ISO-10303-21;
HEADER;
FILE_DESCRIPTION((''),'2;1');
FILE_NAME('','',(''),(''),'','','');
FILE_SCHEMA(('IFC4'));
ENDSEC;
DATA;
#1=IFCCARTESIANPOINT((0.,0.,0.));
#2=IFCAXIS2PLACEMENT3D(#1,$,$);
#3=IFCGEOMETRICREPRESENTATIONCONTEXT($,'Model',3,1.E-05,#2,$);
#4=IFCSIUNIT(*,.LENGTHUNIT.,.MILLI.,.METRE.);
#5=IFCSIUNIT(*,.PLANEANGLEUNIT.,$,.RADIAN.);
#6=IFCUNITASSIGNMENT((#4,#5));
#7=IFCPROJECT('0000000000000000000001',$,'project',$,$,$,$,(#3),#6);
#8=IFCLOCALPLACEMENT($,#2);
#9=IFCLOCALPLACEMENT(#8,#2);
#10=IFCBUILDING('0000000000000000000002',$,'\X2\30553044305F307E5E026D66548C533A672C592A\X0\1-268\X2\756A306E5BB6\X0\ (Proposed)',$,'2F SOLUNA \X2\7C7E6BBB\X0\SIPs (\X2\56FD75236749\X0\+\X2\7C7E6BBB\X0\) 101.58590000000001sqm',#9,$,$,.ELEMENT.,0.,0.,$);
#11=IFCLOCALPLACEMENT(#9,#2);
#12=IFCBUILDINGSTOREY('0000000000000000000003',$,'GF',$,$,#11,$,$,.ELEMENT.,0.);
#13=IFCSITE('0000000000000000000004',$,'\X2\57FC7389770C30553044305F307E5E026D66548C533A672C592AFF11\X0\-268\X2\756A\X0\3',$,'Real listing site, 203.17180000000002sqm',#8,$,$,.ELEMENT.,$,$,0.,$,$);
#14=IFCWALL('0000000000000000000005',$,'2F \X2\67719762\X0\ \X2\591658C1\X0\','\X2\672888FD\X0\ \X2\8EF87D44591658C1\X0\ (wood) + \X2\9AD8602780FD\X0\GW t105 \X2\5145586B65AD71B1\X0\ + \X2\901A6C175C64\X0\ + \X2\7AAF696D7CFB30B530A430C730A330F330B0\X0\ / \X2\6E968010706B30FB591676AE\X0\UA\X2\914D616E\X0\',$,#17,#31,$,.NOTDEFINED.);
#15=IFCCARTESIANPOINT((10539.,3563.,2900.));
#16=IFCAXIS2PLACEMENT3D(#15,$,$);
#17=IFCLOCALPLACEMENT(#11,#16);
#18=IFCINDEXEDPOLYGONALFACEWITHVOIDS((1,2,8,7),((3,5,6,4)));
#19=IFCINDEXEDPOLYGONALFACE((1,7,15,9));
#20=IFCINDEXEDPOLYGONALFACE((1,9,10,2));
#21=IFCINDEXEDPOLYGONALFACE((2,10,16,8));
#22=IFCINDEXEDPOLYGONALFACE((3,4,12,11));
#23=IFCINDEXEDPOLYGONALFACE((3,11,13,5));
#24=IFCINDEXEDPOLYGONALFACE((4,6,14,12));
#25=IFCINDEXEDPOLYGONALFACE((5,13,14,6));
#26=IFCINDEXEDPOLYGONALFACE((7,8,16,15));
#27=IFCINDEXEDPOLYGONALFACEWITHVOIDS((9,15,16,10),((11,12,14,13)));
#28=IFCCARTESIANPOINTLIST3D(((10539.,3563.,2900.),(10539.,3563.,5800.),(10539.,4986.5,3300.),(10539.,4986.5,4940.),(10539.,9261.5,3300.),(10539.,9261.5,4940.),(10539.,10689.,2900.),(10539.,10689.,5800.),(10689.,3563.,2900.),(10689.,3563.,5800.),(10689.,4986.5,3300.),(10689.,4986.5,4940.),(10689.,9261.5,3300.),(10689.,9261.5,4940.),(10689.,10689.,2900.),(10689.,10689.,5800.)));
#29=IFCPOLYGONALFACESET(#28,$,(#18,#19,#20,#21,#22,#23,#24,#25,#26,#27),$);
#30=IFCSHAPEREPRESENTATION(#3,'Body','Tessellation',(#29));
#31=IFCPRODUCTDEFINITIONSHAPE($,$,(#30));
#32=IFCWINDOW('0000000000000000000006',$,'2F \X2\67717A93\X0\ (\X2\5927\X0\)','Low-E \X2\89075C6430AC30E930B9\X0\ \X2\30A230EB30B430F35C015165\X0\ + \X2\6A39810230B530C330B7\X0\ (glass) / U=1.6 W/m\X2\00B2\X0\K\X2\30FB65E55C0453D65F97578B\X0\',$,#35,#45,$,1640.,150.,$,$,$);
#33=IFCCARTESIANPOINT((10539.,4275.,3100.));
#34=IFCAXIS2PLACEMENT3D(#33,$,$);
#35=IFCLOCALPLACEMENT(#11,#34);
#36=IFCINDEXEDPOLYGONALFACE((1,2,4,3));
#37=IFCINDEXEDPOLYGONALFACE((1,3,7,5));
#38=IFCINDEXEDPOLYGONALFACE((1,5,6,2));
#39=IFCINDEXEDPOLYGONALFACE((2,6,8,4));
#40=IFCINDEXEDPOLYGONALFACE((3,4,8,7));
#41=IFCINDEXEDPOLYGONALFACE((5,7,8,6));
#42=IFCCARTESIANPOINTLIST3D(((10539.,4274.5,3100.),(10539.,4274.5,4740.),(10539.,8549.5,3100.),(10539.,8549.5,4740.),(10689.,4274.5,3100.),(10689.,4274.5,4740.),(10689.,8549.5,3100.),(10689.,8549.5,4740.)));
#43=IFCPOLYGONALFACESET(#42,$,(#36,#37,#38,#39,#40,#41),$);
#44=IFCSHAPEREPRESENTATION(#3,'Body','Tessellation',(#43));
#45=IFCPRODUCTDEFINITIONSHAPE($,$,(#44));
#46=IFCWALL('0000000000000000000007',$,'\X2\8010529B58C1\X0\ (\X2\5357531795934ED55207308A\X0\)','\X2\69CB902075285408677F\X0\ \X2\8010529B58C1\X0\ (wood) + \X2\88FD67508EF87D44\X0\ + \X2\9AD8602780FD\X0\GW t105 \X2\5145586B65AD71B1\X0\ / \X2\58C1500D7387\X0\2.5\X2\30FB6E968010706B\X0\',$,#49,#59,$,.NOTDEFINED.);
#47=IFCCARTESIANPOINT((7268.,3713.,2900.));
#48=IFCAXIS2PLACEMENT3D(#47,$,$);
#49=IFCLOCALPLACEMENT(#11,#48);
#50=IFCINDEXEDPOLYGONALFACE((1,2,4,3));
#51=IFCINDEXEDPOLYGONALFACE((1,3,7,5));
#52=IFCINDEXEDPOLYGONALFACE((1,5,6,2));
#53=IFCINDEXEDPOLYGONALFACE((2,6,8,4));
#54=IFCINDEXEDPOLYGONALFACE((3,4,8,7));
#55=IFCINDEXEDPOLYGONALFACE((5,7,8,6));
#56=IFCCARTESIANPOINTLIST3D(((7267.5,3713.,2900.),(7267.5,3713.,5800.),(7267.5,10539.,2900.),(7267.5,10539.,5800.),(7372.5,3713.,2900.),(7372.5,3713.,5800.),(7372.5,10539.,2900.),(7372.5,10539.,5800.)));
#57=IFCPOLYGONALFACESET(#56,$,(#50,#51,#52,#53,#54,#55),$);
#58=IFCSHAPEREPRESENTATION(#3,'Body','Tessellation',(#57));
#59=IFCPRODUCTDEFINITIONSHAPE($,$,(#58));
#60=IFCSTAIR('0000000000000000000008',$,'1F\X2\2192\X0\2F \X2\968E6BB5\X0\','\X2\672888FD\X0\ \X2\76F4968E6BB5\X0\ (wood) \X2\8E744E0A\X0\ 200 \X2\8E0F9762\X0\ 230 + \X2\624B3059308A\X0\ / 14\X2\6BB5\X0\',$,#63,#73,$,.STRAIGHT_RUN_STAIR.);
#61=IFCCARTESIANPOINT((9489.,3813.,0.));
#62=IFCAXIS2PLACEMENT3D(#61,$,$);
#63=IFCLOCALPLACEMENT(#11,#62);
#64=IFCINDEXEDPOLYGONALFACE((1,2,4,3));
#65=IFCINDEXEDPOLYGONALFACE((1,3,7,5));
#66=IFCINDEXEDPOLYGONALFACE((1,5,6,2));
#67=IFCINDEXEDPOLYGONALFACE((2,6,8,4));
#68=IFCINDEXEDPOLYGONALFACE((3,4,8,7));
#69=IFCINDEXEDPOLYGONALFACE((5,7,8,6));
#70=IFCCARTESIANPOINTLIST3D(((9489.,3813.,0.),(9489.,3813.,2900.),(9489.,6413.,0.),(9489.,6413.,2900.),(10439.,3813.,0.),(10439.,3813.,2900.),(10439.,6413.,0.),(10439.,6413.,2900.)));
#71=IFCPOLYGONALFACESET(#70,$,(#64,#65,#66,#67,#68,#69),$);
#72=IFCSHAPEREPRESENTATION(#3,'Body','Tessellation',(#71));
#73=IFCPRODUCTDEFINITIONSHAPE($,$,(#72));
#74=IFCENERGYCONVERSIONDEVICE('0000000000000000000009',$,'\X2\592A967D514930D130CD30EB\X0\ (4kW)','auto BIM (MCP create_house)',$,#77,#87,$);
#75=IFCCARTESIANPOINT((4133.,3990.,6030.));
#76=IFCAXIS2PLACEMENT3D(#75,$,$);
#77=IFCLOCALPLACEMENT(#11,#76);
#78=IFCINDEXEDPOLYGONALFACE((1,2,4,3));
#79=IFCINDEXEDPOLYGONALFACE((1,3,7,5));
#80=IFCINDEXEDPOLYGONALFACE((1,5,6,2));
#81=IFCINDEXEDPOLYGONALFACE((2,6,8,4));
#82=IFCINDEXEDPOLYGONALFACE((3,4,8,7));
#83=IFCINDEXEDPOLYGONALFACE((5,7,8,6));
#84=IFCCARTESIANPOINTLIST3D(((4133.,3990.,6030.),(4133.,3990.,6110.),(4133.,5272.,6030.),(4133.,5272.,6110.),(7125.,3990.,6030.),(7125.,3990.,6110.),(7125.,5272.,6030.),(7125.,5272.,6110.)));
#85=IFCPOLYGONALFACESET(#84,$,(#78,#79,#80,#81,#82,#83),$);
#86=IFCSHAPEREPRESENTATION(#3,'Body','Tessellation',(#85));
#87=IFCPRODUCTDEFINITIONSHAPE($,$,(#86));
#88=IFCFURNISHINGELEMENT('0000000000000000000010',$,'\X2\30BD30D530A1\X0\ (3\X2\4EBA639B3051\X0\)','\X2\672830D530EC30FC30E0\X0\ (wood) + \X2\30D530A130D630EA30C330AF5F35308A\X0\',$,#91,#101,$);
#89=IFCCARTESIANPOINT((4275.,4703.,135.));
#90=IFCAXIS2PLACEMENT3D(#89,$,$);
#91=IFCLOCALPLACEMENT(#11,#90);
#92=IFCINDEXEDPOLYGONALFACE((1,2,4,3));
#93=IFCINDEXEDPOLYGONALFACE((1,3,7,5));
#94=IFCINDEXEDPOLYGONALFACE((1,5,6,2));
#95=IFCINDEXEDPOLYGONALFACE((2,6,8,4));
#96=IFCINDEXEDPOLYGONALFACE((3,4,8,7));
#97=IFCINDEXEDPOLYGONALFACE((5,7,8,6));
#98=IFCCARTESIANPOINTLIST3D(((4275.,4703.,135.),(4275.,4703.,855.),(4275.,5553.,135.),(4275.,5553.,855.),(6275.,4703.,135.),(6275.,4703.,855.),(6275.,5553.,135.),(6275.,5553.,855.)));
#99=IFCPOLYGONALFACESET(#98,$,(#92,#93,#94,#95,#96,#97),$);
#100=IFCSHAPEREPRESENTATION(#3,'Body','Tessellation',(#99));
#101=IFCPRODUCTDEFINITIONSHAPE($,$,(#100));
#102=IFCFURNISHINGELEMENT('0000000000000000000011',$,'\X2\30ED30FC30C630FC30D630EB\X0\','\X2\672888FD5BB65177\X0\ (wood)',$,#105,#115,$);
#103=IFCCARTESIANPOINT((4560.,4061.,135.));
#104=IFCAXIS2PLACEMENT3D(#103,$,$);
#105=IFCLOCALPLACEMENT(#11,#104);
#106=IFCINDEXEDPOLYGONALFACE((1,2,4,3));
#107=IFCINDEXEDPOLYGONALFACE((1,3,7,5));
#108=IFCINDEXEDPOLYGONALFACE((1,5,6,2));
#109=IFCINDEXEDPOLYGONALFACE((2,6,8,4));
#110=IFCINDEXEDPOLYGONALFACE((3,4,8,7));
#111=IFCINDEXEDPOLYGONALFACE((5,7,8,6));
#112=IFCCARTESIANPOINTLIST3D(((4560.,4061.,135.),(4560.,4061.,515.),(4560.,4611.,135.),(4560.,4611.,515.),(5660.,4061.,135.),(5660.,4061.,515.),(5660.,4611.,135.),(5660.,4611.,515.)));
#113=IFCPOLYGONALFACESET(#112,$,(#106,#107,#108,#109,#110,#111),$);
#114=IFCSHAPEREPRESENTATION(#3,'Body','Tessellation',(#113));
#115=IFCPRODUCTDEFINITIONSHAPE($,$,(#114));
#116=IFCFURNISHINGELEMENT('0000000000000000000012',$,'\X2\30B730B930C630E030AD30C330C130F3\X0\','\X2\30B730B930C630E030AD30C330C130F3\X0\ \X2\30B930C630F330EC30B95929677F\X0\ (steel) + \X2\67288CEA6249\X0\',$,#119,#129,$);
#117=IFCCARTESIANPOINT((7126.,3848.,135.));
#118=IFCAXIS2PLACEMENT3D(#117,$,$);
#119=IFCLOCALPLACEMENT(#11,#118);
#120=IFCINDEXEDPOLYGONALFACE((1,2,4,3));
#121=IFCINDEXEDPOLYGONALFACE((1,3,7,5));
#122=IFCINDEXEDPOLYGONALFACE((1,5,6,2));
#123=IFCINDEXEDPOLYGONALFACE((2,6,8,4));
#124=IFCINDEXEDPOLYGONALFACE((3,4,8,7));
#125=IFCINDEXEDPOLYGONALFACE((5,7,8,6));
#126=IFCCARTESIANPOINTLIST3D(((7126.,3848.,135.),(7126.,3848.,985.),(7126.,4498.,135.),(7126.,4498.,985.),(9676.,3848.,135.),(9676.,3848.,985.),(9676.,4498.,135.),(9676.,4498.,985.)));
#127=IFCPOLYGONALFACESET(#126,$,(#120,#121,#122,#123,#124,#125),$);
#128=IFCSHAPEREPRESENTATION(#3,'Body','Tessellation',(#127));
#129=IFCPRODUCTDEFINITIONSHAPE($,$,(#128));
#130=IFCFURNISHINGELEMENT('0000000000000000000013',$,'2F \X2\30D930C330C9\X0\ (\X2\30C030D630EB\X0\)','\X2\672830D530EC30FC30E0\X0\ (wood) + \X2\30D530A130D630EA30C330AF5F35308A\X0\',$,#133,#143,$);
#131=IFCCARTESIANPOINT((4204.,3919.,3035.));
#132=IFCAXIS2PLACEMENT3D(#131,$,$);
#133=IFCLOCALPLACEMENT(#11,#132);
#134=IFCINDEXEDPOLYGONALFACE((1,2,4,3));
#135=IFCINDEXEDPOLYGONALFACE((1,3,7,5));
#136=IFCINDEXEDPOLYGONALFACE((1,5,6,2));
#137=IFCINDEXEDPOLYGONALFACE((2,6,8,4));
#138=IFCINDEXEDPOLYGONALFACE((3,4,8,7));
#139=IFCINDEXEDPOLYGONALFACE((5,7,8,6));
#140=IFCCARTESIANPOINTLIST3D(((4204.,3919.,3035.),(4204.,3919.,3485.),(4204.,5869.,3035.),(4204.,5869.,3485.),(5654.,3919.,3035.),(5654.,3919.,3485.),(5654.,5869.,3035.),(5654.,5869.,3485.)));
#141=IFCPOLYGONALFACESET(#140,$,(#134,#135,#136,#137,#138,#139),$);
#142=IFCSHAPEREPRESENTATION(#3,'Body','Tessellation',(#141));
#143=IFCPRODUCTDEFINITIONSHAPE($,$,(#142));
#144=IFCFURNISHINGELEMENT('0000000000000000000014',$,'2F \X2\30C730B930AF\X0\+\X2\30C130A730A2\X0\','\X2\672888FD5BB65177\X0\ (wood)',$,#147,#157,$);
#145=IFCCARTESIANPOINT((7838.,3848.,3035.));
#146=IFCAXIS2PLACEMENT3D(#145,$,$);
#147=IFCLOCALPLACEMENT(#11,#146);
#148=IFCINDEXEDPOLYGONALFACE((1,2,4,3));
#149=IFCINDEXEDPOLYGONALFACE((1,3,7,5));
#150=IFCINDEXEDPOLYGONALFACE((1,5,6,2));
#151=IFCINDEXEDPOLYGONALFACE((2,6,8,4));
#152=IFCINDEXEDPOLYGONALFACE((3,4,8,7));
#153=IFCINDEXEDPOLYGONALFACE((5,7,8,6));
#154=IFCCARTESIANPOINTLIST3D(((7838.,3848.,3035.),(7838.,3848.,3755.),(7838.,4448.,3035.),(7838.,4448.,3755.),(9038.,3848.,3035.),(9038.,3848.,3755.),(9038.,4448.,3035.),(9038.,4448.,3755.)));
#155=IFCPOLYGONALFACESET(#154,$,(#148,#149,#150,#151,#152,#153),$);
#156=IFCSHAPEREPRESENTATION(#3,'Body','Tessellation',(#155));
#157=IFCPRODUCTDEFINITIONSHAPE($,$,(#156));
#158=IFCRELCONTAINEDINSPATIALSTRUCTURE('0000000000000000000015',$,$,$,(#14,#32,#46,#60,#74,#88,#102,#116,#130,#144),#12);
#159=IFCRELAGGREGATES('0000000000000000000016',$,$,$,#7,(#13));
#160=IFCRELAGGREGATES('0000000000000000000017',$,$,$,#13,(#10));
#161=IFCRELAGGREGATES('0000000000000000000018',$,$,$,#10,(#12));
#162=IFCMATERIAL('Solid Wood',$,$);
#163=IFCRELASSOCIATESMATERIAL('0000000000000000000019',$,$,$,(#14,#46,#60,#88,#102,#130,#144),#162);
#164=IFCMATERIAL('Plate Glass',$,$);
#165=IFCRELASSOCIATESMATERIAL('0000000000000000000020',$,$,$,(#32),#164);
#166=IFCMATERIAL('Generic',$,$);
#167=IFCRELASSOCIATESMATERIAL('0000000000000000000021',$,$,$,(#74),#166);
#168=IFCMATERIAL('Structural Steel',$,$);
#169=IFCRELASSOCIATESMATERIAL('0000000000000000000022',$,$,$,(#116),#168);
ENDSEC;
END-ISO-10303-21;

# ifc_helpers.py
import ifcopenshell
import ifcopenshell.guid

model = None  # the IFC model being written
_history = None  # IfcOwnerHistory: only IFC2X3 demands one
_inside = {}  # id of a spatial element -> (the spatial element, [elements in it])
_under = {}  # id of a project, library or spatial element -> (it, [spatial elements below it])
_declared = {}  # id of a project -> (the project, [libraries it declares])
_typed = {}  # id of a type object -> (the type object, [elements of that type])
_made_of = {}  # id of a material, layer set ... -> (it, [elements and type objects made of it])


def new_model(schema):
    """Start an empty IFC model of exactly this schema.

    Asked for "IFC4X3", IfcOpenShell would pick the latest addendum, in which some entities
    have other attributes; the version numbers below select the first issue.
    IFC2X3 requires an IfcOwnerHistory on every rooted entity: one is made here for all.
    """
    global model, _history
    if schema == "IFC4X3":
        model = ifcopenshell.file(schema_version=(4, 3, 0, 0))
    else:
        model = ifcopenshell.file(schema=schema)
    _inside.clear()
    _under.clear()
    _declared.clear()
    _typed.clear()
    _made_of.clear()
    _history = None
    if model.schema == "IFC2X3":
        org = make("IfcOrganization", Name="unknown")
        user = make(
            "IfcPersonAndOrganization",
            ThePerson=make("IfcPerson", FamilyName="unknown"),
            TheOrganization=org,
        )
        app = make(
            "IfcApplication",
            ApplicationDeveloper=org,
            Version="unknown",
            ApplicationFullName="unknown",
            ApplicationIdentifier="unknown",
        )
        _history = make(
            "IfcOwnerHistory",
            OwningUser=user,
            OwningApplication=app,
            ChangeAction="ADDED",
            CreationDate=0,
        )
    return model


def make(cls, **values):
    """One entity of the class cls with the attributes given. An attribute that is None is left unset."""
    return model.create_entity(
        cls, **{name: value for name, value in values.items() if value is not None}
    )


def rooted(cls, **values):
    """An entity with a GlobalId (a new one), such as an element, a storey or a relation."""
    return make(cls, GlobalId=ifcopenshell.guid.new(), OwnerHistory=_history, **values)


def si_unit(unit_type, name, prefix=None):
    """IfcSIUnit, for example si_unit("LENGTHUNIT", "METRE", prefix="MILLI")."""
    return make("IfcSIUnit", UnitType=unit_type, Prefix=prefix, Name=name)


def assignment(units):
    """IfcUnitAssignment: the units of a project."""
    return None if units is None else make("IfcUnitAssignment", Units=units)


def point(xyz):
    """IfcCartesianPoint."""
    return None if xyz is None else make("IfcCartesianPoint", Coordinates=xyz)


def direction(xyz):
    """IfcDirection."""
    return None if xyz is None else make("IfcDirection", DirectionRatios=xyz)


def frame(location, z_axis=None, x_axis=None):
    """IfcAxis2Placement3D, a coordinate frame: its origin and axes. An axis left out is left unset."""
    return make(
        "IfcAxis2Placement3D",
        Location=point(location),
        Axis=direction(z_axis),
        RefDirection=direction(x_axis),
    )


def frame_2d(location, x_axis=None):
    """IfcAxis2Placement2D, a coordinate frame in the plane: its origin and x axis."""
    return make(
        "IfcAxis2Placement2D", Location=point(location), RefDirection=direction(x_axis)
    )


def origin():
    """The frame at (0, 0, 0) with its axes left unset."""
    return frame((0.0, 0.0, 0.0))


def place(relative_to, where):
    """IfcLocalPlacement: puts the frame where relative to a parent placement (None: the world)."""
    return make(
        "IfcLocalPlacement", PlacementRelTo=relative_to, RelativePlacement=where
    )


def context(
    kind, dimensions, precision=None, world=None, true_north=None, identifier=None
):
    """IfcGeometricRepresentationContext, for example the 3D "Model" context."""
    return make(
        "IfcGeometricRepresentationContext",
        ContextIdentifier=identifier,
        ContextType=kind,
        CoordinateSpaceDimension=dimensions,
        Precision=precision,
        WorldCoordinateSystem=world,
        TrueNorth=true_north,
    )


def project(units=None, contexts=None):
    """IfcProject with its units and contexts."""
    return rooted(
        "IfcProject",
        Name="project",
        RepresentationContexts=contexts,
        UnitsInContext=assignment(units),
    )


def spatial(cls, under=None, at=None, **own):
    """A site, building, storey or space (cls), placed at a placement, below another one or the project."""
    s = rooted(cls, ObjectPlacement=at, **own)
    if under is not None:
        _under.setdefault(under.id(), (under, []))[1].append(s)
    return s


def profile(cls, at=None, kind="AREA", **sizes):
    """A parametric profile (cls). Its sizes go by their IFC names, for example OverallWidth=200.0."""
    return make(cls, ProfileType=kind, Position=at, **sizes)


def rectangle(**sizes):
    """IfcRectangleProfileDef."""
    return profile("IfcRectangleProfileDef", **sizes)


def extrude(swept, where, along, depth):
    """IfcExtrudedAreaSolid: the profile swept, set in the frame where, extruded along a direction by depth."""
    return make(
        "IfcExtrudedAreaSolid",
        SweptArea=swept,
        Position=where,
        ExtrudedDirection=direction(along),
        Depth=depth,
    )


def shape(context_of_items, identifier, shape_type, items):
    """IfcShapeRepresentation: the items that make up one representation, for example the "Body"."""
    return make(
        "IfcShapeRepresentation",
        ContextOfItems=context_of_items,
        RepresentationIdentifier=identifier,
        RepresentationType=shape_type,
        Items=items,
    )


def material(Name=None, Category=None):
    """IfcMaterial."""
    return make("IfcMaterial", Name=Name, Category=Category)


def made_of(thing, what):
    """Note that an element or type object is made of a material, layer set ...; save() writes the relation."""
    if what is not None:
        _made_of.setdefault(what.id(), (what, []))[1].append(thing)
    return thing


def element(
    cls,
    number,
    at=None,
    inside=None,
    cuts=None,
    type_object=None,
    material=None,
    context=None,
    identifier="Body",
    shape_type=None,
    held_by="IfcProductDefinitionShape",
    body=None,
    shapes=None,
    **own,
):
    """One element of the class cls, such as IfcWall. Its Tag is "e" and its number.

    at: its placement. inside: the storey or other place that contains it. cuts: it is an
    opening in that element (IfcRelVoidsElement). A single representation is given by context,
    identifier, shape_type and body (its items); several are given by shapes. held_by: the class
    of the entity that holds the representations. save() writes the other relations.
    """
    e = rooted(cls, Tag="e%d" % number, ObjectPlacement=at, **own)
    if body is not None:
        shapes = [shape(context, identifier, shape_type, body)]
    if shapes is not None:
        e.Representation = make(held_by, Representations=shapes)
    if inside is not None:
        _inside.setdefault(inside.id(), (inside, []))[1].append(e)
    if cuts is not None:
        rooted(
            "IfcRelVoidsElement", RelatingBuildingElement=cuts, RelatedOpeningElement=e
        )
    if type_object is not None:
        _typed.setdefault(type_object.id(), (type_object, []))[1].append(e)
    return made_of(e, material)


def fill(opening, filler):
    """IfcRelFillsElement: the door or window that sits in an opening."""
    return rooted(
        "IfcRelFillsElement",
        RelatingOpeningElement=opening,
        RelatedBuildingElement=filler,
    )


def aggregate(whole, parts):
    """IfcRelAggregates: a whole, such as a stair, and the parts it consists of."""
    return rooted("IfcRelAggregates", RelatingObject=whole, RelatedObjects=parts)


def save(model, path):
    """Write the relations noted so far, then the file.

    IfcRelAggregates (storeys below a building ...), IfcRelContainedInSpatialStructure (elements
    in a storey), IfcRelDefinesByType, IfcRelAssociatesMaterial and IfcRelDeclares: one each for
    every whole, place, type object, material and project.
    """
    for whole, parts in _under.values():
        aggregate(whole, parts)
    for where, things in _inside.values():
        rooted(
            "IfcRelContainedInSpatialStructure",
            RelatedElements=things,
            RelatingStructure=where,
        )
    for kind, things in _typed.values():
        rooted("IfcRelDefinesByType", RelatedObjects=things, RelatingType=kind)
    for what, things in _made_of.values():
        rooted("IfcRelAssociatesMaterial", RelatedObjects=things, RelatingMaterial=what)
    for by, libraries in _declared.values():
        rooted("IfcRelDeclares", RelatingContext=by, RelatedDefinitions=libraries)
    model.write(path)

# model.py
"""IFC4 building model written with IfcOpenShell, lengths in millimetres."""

from ifc_helpers import new_model, si_unit, frame, frame_2d, origin, place, context, project, spatial, rectangle, extrude, material, element, fill, save


model = new_model("IFC4")

# Units and contexts
model_context = context("Model", 3, precision=1e-05, world=origin())
ifc_project = project(units=[si_unit("LENGTHUNIT", "METRE", prefix="MILLI"), si_unit("PLANEANGLEUNIT", "RADIAN")], contexts=[model_context])

# Site, building, storey
site_placement = place(None, origin())
site = spatial("IfcSite", under=ifc_project, at=site_placement, Name="埼玉県さいたま市浦和区本太１-268番3", ObjectType="Real listing site, 203.17180000000002sqm", CompositionType="ELEMENT", RefElevation=0.0)
building_placement = place(site_placement, origin())
building = spatial("IfcBuilding", under=site, at=building_placement, Name="さいたま市浦和区本太1-268番の家 (Proposed)", ObjectType="2F SOLUNA 籾殻SIPs (国産杉+籾殻) 101.58590000000001sqm", CompositionType="ELEMENT", ElevationOfRefHeight=0.0, ElevationOfTerrain=0.0)
storey_placement = place(building_placement, origin())
storey = spatial("IfcBuildingStorey", under=building, at=storey_placement, Name="GF", CompositionType="ELEMENT", Elevation=0.0)

# Shared definitions
ifc_material_1 = material(Name="Solid Wood")
ifc_material_2 = material(Name="Plate Glass")

# Wall, opening, window
wall_1_placement = place(storey_placement, frame((10539.0, 3563.0, 2900.0)))
wall_1 = element("IfcWall", 1, at=wall_1_placement, inside=storey, material=ifc_material_1, Name="2F 東面 外壁", Description="木製 軸組外壁 (wood) + 高性能GW t105 充填断熱 + 通気層 + 窯業系サイディング / 準耐火・外皮UA配慮", PredefinedType="NOTDEFINED", context=model_context, shape_type="SweptSolid", body=[
    extrude(rectangle(XDim=150.0, YDim=7126.0, at=frame_2d((75.0, 3563.0))), frame((10539.0, 3563.0, 2900.0)), (0.0, 0.0, 1.0), 2900.0),
])
opening_1_placement = place(storey_placement, frame((10539.0, 4275.0, 3100.0)))
opening_1 = element("IfcOpeningElement", 2, at=opening_1_placement, cuts=wall_1, PredefinedType="NOTDEFINED", context=model_context, shape_type="SweptSolid", body=[
    extrude(rectangle(XDim=150.0, YDim=4275.0, at=frame_2d((75.0, 2137.0))), frame((10539.0, 4275.0, 3100.0)), (0.0, 0.0, 1.0), 1640.0),
])
window_1_placement = place(storey_placement, frame((10539.0, 4275.0, 3100.0)))
window_1 = element("IfcWindow", 3, at=window_1_placement, inside=storey, material=ifc_material_2, Name="2F 東窓 (大)", Description="Low-E 複層ガラス アルゴン封入 + 樹脂サッシ (glass) / U=1.6 W/m²K・日射取得型", OverallHeight=1640.0, OverallWidth=150.0, context=model_context, shape_type="SweptSolid", body=[
    extrude(rectangle(XDim=150.0, YDim=4275.0, at=frame_2d((75.0, 2137.0))), frame((10539.0, 4275.0, 3100.0)), (0.0, 0.0, 1.0), 1640.0),
])
fill(opening_1, window_1)

# Wall
wall_2_placement = place(storey_placement, frame((7268.0, 3713.0, 2900.0)))
element("IfcWall", 4, at=wall_2_placement, inside=storey, material=ifc_material_1, Name="耐力壁 (南北間仕切り)", Description="構造用合板 耐力壁 (wood) + 製材軸組 + 高性能GW t105 充填断熱 / 壁倍率2.5・準耐火", PredefinedType="NOTDEFINED", context=model_context, shape_type="SweptSolid", body=[
    extrude(rectangle(XDim=105.0, YDim=6826.0, at=frame_2d((52.0, 3413.0))), frame((7268.0, 3713.0, 2900.0)), (0.0, 0.0, 1.0), 2900.0),
])

# Stair
stair_placement = place(storey_placement, frame((9489.0, 3813.0, 0.0)))
element("IfcStair", 5, at=stair_placement, inside=storey, material=ifc_material_1, Name="1F→2F 階段", Description="木製 直階段 (wood) 蹴上 200 踏面 230 + 手すり / 14段", PredefinedType="STRAIGHT_RUN_STAIR", context=model_context, shape_type="SweptSolid", body=[
    extrude(rectangle(XDim=950.0, YDim=2600.0, at=frame_2d((475.0, 1300.0))), frame((9489.0, 3813.0, 0.0)), (0.0, 0.0, 1.0), 2900.0),
])

# Energy conversion device
ifc_material_3 = material(Name="Generic")
energy_conversion_device_placement = place(storey_placement, frame((4133.0, 3990.0, 6030.0)))
element("IfcEnergyConversionDevice", 6, at=energy_conversion_device_placement, inside=storey, material=ifc_material_3, Name="太陽光パネル (4kW)", Description="auto BIM (MCP create_house)", context=model_context, shape_type="SweptSolid", body=[
    extrude(rectangle(XDim=2992.0, YDim=1282.0, at=frame_2d((1496.0, 641.0))), frame((4133.0, 3990.0, 6030.0)), (0.0, 0.0, 1.0), 80.0),
])

# Furnishing elements
furnishing_1_placement = place(storey_placement, frame((4275.0, 4703.0, 135.0)))
element("IfcFurnishingElement", 7, at=furnishing_1_placement, inside=storey, material=ifc_material_1, Name="ソファ (3人掛け)", Description="木フレーム (wood) + ファブリック張り", context=model_context, shape_type="SweptSolid", body=[
    extrude(rectangle(XDim=2000.0, YDim=850.0, at=frame_2d((1000.0, 425.0))), frame((4275.0, 4703.0, 135.0)), (0.0, 0.0, 1.0), 720.0),
])
furnishing_2_placement = place(storey_placement, frame((4560.0, 4061.0, 135.0)))
element("IfcFurnishingElement", 8, at=furnishing_2_placement, inside=storey, material=ifc_material_1, Name="ローテーブル", Description="木製家具 (wood)", context=model_context, shape_type="SweptSolid", body=[
    extrude(rectangle(XDim=1100.0, YDim=550.0, at=frame_2d((550.0, 275.0))), frame((4560.0, 4061.0, 135.0)), (0.0, 0.0, 1.0), 380.0),
])
ifc_material_4 = material(Name="Structural Steel")
furnishing_3_placement = place(storey_placement, frame((7126.0, 3848.0, 135.0)))
element("IfcFurnishingElement", 9, at=furnishing_3_placement, inside=storey, material=ifc_material_4, Name="システムキッチン", Description="システムキッチン ステンレス天板 (steel) + 木質扉", context=model_context, shape_type="SweptSolid", body=[
    extrude(rectangle(XDim=2550.0, YDim=650.0, at=frame_2d((1275.0, 325.0))), frame((7126.0, 3848.0, 135.0)), (0.0, 0.0, 1.0), 850.0),
])
furnishing_4_placement = place(storey_placement, frame((4204.0, 3919.0, 3035.0)))
element("IfcFurnishingElement", 10, at=furnishing_4_placement, inside=storey, material=ifc_material_1, Name="2F ベッド (ダブル)", Description="木フレーム (wood) + ファブリック張り", context=model_context, shape_type="SweptSolid", body=[
    extrude(rectangle(XDim=1450.0, YDim=1950.0, at=frame_2d((725.0, 975.0))), frame((4204.0, 3919.0, 3035.0)), (0.0, 0.0, 1.0), 450.0),
])
furnishing_5_placement = place(storey_placement, frame((7838.0, 3848.0, 3035.0)))
element("IfcFurnishingElement", 11, at=furnishing_5_placement, inside=storey, material=ifc_material_1, Name="2F デスク+チェア", Description="木製家具 (wood)", context=model_context, shape_type="SweptSolid", body=[
    extrude(rectangle(XDim=1200.0, YDim=600.0, at=frame_2d((600.0, 300.0))), frame((7838.0, 3848.0, 3035.0)), (0.0, 0.0, 1.0), 720.0),
])

save(model, "model.ifc")
